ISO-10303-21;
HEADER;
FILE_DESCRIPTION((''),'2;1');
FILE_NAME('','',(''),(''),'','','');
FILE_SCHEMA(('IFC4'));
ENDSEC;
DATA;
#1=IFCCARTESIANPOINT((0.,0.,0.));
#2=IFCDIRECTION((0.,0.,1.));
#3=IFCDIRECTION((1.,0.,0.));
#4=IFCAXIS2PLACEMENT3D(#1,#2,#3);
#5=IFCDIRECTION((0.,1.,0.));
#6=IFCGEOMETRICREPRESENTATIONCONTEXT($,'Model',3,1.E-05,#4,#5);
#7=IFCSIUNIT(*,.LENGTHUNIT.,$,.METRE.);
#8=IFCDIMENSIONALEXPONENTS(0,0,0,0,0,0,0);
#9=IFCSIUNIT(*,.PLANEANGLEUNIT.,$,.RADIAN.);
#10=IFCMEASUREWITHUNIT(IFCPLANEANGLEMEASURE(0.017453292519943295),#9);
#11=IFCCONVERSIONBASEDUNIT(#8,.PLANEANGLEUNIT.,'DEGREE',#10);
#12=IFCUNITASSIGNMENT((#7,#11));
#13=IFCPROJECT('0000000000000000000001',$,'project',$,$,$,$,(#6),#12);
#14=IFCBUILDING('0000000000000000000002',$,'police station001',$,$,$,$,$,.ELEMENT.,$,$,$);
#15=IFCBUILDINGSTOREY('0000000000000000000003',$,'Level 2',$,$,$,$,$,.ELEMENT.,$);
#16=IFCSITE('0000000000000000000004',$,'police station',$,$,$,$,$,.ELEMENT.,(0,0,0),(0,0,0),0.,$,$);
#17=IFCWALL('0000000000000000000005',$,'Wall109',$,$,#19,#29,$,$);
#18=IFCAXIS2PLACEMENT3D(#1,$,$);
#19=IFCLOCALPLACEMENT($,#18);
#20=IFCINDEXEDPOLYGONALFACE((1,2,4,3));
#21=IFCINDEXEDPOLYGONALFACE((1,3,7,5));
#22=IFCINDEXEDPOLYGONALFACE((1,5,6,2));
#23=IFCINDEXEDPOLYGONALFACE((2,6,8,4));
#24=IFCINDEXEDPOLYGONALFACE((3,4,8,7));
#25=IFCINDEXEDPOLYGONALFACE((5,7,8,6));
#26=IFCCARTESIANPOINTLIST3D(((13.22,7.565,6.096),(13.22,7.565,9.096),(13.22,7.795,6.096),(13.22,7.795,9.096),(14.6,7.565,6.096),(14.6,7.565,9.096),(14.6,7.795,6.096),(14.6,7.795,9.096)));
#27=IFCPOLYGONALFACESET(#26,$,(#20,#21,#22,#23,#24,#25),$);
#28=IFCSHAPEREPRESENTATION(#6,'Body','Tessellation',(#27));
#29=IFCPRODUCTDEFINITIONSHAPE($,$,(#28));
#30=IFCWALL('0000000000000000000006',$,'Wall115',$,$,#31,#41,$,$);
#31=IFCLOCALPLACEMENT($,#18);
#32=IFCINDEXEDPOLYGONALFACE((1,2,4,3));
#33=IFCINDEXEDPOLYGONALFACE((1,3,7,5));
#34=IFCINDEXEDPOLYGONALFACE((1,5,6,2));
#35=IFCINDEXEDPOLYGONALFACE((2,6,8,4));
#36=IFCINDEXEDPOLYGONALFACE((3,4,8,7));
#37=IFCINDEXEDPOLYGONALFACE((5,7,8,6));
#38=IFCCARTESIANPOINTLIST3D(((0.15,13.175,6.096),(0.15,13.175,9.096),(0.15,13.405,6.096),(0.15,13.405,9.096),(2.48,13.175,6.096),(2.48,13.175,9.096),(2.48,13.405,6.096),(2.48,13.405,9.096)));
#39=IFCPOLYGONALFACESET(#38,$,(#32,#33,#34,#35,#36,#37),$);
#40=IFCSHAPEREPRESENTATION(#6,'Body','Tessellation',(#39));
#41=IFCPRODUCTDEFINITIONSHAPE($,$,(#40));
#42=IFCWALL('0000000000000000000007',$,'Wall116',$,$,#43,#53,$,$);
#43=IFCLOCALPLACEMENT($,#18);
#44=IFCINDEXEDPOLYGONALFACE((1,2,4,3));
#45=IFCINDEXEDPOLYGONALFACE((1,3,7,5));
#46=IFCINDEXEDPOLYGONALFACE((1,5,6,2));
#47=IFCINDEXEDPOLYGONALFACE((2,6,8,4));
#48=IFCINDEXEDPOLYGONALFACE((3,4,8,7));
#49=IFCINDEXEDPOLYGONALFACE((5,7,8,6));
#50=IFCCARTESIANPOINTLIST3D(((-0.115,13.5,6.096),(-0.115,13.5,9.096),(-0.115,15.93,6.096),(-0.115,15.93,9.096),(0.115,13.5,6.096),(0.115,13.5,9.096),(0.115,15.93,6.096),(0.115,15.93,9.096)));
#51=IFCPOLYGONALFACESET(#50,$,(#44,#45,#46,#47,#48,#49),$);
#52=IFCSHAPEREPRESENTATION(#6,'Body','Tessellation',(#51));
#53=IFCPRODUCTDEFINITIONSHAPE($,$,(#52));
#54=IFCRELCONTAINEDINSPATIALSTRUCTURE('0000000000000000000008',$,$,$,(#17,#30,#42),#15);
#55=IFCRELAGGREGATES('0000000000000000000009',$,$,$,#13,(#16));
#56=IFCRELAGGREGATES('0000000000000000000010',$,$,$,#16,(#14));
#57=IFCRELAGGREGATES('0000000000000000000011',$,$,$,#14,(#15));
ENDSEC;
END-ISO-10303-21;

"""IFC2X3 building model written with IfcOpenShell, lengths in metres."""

from ifc_helpers import new_model, entity, si_unit, converted_unit, direction, frame, frame_2d, origin_with_axes, place, context, project, spatial, rectangle, extrude, element, save


model = new_model("IFC2X3")

# Units and contexts
model_context = context("Model", 3, precision=1e-05, world=origin_with_axes(), true_north=direction((0.0, 1.0, 0.0)))
ifc_project = project(units=[si_unit("LENGTHUNIT", "METRE"), converted_unit("PLANEANGLEUNIT", "DEGREE", entity("IfcPlaneAngleMeasure", 0.017453292519943295), si_unit("PLANEANGLEUNIT", "RADIAN"), dimensions=[0, 0, 0, 0, 0, 0, 0])], contexts=[model_context])

# Site, building, storey
site = spatial("IfcSite", under=ifc_project, Name="police station", CompositionType="ELEMENT", RefLatitude=(0, 0, 0), RefLongitude=(0, 0, 0), RefElevation=0.0)
building = spatial("IfcBuilding", under=site, Name="police station001", CompositionType="ELEMENT")
storey = spatial("IfcBuildingStorey", under=building, Name="Level 2", CompositionType="ELEMENT")

# Shared definitions
placement = place(None, origin_with_axes())

# Walls
element("IfcWall", 1, at=placement, inside=storey, Name="Wall109", context=model_context, shape_type="SweptSolid", body=[
    extrude(rectangle(XDim=1.38, YDim=0.23, at=frame_2d((0.0, 0.0), x_axis=(1.0, 0.0, 0.0))), frame((13.91, 7.68, 6.096), z_axis=(0.0, 0.0, 1.0), x_axis=(1.0, 0.0, 0.0)), (0.0, 0.0, 1.0), 3.0),
])
element("IfcWall", 2, at=placement, inside=storey, Name="Wall115", context=model_context, shape_type="SweptSolid", body=[
    extrude(rectangle(XDim=2.33, YDim=0.23, at=frame_2d((0.0, 0.0), x_axis=(1.0, 0.0, 0.0))), frame((1.315, 13.29, 6.096), z_axis=(0.0, 0.0, 1.0), x_axis=(1.0, 0.0, 0.0)), (0.0, 0.0, 1.0), 3.0),
])
element("IfcWall", 3, at=placement, inside=storey, Name="Wall116", context=model_context, shape_type="SweptSolid", body=[
    extrude(rectangle(XDim=2.43, YDim=0.23, at=frame_2d((0.0, 0.0), x_axis=(0.0, -1.0, 0.0))), frame((0.0, 14.715, 6.096), z_axis=(0.0, 0.0, 1.0), x_axis=(1.0, 0.0, 0.0)), (0.0, 0.0, 1.0), 3.0),
])

save(model, "model.ifc")
